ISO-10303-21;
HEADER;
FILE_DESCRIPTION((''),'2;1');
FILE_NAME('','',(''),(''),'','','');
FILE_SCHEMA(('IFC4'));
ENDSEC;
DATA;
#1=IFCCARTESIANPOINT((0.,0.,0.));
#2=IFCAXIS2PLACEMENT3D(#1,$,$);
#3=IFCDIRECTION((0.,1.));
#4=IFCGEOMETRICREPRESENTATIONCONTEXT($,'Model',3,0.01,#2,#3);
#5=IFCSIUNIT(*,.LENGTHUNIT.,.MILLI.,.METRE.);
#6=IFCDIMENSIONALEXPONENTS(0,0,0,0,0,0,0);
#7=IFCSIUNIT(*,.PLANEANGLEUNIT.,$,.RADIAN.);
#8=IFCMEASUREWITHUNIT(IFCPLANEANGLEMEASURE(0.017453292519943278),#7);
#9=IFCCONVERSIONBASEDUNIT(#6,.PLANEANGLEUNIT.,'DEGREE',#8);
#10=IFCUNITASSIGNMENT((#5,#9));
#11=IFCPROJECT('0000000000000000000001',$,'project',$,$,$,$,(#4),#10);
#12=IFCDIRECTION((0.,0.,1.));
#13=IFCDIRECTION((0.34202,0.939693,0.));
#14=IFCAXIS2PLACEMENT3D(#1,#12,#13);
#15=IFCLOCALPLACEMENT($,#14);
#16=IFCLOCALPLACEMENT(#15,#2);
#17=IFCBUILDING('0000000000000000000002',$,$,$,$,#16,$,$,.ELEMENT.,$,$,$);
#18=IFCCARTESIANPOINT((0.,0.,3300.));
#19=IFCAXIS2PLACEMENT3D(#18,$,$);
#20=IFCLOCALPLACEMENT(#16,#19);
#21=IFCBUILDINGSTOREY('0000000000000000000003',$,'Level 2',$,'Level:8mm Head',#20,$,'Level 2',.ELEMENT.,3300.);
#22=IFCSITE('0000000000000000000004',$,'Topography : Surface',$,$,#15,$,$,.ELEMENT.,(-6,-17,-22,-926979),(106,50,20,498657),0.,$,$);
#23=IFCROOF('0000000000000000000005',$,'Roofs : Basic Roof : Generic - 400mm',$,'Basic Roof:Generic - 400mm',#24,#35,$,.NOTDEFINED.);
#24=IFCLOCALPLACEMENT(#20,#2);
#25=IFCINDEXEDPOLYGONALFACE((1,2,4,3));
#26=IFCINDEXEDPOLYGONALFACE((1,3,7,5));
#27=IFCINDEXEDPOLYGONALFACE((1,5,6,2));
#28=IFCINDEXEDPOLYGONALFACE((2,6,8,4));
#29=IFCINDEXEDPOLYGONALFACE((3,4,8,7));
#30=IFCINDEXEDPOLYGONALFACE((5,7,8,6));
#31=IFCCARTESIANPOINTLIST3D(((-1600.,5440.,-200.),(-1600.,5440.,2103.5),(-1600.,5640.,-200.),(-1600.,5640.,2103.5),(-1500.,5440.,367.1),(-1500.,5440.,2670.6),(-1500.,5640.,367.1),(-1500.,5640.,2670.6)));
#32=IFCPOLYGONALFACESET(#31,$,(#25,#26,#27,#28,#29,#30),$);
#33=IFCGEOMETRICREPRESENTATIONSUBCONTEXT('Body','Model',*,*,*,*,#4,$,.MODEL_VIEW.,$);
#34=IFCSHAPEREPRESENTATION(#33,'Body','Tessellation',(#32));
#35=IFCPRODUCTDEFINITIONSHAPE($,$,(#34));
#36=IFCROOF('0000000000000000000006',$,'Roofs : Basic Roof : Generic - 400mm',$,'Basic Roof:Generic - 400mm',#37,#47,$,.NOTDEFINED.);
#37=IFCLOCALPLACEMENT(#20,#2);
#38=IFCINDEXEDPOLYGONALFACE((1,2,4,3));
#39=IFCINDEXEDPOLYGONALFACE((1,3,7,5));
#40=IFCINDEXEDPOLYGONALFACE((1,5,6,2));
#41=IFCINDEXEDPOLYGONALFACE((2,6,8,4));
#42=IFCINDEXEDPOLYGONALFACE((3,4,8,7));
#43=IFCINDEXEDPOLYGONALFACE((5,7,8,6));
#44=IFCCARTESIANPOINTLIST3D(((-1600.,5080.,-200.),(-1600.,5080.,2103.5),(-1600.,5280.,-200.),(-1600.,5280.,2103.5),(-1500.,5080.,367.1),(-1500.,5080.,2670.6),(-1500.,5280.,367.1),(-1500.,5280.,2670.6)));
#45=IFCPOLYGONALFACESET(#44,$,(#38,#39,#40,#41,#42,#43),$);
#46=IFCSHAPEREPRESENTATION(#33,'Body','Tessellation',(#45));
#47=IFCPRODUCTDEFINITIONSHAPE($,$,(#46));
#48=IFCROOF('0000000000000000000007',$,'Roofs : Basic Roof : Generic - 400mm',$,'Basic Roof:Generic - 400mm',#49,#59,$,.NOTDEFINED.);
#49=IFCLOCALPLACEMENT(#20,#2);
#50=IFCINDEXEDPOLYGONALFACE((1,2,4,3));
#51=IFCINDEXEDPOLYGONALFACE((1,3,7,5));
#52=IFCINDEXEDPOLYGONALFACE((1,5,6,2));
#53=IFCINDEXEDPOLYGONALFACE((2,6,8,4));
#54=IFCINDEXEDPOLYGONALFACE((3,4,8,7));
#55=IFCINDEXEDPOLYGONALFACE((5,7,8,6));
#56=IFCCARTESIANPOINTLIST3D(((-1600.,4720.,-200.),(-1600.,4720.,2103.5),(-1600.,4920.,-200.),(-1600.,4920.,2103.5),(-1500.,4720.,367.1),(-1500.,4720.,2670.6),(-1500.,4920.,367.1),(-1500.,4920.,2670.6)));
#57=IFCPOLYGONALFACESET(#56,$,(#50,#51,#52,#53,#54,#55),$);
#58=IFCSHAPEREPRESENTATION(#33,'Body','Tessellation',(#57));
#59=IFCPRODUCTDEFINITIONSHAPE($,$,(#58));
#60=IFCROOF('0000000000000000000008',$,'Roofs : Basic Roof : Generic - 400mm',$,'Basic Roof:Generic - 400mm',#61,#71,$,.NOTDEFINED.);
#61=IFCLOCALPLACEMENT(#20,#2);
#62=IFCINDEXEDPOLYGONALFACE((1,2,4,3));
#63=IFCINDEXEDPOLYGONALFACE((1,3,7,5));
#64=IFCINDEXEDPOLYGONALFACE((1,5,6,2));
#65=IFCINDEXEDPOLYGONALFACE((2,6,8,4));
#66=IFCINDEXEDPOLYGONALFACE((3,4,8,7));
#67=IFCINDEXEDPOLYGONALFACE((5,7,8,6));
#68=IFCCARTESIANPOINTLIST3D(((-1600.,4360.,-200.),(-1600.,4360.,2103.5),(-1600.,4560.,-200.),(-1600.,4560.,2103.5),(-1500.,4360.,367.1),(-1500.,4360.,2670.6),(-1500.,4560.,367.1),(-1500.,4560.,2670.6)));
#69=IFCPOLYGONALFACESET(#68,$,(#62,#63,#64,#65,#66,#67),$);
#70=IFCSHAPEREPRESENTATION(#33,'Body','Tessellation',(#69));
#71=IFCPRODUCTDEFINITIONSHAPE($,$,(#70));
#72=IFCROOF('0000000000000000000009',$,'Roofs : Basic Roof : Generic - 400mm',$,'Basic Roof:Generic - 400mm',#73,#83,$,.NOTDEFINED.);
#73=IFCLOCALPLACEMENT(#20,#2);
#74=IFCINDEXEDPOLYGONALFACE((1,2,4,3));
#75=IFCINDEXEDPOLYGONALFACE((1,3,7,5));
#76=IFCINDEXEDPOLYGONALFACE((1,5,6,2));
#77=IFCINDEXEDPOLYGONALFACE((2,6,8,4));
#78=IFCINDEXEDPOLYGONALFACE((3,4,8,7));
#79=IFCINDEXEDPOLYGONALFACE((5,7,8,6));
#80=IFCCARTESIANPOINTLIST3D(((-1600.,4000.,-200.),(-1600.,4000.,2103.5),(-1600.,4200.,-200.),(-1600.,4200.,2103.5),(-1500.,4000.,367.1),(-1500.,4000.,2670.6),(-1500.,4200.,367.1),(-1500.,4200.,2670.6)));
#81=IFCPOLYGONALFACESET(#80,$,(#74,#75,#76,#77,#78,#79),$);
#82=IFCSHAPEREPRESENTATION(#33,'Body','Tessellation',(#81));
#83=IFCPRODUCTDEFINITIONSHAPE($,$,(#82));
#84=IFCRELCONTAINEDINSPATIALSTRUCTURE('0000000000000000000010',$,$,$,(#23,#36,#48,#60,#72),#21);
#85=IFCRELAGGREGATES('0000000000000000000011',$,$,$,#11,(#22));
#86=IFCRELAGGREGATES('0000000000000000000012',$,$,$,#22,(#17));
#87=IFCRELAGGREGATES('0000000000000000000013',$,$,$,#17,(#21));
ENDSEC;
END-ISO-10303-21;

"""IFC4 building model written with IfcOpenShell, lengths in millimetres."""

from ifc_helpers import new_model, entity, si_unit, converted_unit, direction, frame, origin, place, context, subcontext, project, spatial, indexed_curve, outline, extrude, element, save


model = new_model("IFC4")

# Units and contexts
model_context = context("Model", 3, precision=0.01, world=origin(), true_north=direction((0.0, 1.0)))
body_context = subcontext(model_context, "Body", "Model", "MODEL_VIEW")
ifc_project = project(units=[si_unit("LENGTHUNIT", "METRE", prefix="MILLI"), converted_unit("PLANEANGLEUNIT", "DEGREE", entity("IfcPlaneAngleMeasure", 0.017453292519943278), si_unit("PLANEANGLEUNIT", "RADIAN"), dimensions=[0, 0, 0, 0, 0, 0, 0])], contexts=[model_context])

# Site, building, storey
site_placement = place(None, frame((0.0, 0.0, 0.0), z_axis=(0.0, 0.0, 1.0), x_axis=(0.34202, 0.939693, 0.0)))
site = spatial("IfcSite", under=ifc_project, at=site_placement, Name="Topography : Surface", CompositionType="ELEMENT", RefLatitude=(-6, -17, -22, -926979), RefLongitude=(106, 50, 20, 498657), RefElevation=0.0)
building_placement = place(site_placement, origin())
building = spatial("IfcBuilding", under=site, at=building_placement, CompositionType="ELEMENT")
storey_placement = place(building_placement, frame((0.0, 0.0, 3300.0)))
storey = spatial("IfcBuildingStorey", under=building, at=storey_placement, Name="Level 2", ObjectType="Level:8mm Head", LongName="Level 2", CompositionType="ELEMENT", Elevation=3300.0)

# Roofs
roof_1_placement = place(storey_placement, frame((-1600.0, 5440.0, -200.0)))
element("IfcRoof", 1, at=roof_1_placement, inside=storey, Name="Roofs : Basic Roof : Generic - 400mm", ObjectType="Basic Roof:Generic - 400mm", PredefinedType="NOTDEFINED", context=body_context, shape_type="SweptSolid", body=[
    extrude(outline(indexed_curve([(-287.9, 100.0), (-287.9, -100.0), (287.9, -100.0), (287.9, 100.0), (-287.9, 100.0)], self_intersect=False)), frame((50.0, 100.0, 283.6), z_axis=(-0.984808, 0.0, 0.173648), x_axis=(0.173648, 0.0, 0.984808)), (0.984808, 0.0, 0.173648), 2303.5),
])
roof_2_placement = place(storey_placement, frame((-1600.0, 5080.0, -200.0)))
element("IfcRoof", 2, at=roof_2_placement, inside=storey, Name="Roofs : Basic Roof : Generic - 400mm", ObjectType="Basic Roof:Generic - 400mm", PredefinedType="NOTDEFINED", context=body_context, shape_type="SweptSolid", body=[
    extrude(outline(indexed_curve([(-287.9, 100.0), (-287.9, -100.0), (287.9, -100.0), (287.9, 100.0), (-287.9, 100.0)], self_intersect=False)), frame((50.0, 100.0, 283.6), z_axis=(-0.984808, 0.0, 0.173648), x_axis=(0.173648, 0.0, 0.984808)), (0.984808, 0.0, 0.173648), 2303.5),
])
roof_3_placement = place(storey_placement, frame((-1600.0, 4720.0, -200.0)))
element("IfcRoof", 3, at=roof_3_placement, inside=storey, Name="Roofs : Basic Roof : Generic - 400mm", ObjectType="Basic Roof:Generic - 400mm", PredefinedType="NOTDEFINED", context=body_context, shape_type="SweptSolid", body=[
    extrude(outline(indexed_curve([(-287.9, 100.0), (-287.9, -100.0), (287.9, -100.0), (287.9, 100.0), (-287.9, 100.0)], self_intersect=False)), frame((50.0, 100.0, 283.6), z_axis=(-0.984808, 0.0, 0.173648), x_axis=(0.173648, 0.0, 0.984808)), (0.984808, 0.0, 0.173648), 2303.5),
])
roof_4_placement = place(storey_placement, frame((-1600.0, 4360.0, -200.0)))
element("IfcRoof", 4, at=roof_4_placement, inside=storey, Name="Roofs : Basic Roof : Generic - 400mm", ObjectType="Basic Roof:Generic - 400mm", PredefinedType="NOTDEFINED", context=body_context, shape_type="SweptSolid", body=[
    extrude(outline(indexed_curve([(-287.9, 100.0), (-287.9, -100.0), (287.9, -100.0), (287.9, 100.0), (-287.9, 100.0)], self_intersect=False)), frame((50.0, 100.0, 283.6), z_axis=(-0.984808, 0.0, 0.173648), x_axis=(0.173648, 0.0, 0.984808)), (0.984808, 0.0, 0.173648), 2303.5),
])
roof_5_placement = place(storey_placement, frame((-1600.0, 4000.0, -200.0)))
element("IfcRoof", 5, at=roof_5_placement, inside=storey, Name="Roofs : Basic Roof : Generic - 400mm", ObjectType="Basic Roof:Generic - 400mm", PredefinedType="NOTDEFINED", context=body_context, shape_type="SweptSolid", body=[
    extrude(outline(indexed_curve([(-287.9, 100.0), (-287.9, -100.0), (287.9, -100.0), (287.9, 100.0), (-287.9, 100.0)], self_intersect=False)), frame((50.0, 100.0, 283.6), z_axis=(-0.984808, 0.0, 0.173648), x_axis=(0.173648, 0.0, 0.984808)), (0.984808, 0.0, 0.173648), 2303.5),
])

save(model, "model.ifc")
